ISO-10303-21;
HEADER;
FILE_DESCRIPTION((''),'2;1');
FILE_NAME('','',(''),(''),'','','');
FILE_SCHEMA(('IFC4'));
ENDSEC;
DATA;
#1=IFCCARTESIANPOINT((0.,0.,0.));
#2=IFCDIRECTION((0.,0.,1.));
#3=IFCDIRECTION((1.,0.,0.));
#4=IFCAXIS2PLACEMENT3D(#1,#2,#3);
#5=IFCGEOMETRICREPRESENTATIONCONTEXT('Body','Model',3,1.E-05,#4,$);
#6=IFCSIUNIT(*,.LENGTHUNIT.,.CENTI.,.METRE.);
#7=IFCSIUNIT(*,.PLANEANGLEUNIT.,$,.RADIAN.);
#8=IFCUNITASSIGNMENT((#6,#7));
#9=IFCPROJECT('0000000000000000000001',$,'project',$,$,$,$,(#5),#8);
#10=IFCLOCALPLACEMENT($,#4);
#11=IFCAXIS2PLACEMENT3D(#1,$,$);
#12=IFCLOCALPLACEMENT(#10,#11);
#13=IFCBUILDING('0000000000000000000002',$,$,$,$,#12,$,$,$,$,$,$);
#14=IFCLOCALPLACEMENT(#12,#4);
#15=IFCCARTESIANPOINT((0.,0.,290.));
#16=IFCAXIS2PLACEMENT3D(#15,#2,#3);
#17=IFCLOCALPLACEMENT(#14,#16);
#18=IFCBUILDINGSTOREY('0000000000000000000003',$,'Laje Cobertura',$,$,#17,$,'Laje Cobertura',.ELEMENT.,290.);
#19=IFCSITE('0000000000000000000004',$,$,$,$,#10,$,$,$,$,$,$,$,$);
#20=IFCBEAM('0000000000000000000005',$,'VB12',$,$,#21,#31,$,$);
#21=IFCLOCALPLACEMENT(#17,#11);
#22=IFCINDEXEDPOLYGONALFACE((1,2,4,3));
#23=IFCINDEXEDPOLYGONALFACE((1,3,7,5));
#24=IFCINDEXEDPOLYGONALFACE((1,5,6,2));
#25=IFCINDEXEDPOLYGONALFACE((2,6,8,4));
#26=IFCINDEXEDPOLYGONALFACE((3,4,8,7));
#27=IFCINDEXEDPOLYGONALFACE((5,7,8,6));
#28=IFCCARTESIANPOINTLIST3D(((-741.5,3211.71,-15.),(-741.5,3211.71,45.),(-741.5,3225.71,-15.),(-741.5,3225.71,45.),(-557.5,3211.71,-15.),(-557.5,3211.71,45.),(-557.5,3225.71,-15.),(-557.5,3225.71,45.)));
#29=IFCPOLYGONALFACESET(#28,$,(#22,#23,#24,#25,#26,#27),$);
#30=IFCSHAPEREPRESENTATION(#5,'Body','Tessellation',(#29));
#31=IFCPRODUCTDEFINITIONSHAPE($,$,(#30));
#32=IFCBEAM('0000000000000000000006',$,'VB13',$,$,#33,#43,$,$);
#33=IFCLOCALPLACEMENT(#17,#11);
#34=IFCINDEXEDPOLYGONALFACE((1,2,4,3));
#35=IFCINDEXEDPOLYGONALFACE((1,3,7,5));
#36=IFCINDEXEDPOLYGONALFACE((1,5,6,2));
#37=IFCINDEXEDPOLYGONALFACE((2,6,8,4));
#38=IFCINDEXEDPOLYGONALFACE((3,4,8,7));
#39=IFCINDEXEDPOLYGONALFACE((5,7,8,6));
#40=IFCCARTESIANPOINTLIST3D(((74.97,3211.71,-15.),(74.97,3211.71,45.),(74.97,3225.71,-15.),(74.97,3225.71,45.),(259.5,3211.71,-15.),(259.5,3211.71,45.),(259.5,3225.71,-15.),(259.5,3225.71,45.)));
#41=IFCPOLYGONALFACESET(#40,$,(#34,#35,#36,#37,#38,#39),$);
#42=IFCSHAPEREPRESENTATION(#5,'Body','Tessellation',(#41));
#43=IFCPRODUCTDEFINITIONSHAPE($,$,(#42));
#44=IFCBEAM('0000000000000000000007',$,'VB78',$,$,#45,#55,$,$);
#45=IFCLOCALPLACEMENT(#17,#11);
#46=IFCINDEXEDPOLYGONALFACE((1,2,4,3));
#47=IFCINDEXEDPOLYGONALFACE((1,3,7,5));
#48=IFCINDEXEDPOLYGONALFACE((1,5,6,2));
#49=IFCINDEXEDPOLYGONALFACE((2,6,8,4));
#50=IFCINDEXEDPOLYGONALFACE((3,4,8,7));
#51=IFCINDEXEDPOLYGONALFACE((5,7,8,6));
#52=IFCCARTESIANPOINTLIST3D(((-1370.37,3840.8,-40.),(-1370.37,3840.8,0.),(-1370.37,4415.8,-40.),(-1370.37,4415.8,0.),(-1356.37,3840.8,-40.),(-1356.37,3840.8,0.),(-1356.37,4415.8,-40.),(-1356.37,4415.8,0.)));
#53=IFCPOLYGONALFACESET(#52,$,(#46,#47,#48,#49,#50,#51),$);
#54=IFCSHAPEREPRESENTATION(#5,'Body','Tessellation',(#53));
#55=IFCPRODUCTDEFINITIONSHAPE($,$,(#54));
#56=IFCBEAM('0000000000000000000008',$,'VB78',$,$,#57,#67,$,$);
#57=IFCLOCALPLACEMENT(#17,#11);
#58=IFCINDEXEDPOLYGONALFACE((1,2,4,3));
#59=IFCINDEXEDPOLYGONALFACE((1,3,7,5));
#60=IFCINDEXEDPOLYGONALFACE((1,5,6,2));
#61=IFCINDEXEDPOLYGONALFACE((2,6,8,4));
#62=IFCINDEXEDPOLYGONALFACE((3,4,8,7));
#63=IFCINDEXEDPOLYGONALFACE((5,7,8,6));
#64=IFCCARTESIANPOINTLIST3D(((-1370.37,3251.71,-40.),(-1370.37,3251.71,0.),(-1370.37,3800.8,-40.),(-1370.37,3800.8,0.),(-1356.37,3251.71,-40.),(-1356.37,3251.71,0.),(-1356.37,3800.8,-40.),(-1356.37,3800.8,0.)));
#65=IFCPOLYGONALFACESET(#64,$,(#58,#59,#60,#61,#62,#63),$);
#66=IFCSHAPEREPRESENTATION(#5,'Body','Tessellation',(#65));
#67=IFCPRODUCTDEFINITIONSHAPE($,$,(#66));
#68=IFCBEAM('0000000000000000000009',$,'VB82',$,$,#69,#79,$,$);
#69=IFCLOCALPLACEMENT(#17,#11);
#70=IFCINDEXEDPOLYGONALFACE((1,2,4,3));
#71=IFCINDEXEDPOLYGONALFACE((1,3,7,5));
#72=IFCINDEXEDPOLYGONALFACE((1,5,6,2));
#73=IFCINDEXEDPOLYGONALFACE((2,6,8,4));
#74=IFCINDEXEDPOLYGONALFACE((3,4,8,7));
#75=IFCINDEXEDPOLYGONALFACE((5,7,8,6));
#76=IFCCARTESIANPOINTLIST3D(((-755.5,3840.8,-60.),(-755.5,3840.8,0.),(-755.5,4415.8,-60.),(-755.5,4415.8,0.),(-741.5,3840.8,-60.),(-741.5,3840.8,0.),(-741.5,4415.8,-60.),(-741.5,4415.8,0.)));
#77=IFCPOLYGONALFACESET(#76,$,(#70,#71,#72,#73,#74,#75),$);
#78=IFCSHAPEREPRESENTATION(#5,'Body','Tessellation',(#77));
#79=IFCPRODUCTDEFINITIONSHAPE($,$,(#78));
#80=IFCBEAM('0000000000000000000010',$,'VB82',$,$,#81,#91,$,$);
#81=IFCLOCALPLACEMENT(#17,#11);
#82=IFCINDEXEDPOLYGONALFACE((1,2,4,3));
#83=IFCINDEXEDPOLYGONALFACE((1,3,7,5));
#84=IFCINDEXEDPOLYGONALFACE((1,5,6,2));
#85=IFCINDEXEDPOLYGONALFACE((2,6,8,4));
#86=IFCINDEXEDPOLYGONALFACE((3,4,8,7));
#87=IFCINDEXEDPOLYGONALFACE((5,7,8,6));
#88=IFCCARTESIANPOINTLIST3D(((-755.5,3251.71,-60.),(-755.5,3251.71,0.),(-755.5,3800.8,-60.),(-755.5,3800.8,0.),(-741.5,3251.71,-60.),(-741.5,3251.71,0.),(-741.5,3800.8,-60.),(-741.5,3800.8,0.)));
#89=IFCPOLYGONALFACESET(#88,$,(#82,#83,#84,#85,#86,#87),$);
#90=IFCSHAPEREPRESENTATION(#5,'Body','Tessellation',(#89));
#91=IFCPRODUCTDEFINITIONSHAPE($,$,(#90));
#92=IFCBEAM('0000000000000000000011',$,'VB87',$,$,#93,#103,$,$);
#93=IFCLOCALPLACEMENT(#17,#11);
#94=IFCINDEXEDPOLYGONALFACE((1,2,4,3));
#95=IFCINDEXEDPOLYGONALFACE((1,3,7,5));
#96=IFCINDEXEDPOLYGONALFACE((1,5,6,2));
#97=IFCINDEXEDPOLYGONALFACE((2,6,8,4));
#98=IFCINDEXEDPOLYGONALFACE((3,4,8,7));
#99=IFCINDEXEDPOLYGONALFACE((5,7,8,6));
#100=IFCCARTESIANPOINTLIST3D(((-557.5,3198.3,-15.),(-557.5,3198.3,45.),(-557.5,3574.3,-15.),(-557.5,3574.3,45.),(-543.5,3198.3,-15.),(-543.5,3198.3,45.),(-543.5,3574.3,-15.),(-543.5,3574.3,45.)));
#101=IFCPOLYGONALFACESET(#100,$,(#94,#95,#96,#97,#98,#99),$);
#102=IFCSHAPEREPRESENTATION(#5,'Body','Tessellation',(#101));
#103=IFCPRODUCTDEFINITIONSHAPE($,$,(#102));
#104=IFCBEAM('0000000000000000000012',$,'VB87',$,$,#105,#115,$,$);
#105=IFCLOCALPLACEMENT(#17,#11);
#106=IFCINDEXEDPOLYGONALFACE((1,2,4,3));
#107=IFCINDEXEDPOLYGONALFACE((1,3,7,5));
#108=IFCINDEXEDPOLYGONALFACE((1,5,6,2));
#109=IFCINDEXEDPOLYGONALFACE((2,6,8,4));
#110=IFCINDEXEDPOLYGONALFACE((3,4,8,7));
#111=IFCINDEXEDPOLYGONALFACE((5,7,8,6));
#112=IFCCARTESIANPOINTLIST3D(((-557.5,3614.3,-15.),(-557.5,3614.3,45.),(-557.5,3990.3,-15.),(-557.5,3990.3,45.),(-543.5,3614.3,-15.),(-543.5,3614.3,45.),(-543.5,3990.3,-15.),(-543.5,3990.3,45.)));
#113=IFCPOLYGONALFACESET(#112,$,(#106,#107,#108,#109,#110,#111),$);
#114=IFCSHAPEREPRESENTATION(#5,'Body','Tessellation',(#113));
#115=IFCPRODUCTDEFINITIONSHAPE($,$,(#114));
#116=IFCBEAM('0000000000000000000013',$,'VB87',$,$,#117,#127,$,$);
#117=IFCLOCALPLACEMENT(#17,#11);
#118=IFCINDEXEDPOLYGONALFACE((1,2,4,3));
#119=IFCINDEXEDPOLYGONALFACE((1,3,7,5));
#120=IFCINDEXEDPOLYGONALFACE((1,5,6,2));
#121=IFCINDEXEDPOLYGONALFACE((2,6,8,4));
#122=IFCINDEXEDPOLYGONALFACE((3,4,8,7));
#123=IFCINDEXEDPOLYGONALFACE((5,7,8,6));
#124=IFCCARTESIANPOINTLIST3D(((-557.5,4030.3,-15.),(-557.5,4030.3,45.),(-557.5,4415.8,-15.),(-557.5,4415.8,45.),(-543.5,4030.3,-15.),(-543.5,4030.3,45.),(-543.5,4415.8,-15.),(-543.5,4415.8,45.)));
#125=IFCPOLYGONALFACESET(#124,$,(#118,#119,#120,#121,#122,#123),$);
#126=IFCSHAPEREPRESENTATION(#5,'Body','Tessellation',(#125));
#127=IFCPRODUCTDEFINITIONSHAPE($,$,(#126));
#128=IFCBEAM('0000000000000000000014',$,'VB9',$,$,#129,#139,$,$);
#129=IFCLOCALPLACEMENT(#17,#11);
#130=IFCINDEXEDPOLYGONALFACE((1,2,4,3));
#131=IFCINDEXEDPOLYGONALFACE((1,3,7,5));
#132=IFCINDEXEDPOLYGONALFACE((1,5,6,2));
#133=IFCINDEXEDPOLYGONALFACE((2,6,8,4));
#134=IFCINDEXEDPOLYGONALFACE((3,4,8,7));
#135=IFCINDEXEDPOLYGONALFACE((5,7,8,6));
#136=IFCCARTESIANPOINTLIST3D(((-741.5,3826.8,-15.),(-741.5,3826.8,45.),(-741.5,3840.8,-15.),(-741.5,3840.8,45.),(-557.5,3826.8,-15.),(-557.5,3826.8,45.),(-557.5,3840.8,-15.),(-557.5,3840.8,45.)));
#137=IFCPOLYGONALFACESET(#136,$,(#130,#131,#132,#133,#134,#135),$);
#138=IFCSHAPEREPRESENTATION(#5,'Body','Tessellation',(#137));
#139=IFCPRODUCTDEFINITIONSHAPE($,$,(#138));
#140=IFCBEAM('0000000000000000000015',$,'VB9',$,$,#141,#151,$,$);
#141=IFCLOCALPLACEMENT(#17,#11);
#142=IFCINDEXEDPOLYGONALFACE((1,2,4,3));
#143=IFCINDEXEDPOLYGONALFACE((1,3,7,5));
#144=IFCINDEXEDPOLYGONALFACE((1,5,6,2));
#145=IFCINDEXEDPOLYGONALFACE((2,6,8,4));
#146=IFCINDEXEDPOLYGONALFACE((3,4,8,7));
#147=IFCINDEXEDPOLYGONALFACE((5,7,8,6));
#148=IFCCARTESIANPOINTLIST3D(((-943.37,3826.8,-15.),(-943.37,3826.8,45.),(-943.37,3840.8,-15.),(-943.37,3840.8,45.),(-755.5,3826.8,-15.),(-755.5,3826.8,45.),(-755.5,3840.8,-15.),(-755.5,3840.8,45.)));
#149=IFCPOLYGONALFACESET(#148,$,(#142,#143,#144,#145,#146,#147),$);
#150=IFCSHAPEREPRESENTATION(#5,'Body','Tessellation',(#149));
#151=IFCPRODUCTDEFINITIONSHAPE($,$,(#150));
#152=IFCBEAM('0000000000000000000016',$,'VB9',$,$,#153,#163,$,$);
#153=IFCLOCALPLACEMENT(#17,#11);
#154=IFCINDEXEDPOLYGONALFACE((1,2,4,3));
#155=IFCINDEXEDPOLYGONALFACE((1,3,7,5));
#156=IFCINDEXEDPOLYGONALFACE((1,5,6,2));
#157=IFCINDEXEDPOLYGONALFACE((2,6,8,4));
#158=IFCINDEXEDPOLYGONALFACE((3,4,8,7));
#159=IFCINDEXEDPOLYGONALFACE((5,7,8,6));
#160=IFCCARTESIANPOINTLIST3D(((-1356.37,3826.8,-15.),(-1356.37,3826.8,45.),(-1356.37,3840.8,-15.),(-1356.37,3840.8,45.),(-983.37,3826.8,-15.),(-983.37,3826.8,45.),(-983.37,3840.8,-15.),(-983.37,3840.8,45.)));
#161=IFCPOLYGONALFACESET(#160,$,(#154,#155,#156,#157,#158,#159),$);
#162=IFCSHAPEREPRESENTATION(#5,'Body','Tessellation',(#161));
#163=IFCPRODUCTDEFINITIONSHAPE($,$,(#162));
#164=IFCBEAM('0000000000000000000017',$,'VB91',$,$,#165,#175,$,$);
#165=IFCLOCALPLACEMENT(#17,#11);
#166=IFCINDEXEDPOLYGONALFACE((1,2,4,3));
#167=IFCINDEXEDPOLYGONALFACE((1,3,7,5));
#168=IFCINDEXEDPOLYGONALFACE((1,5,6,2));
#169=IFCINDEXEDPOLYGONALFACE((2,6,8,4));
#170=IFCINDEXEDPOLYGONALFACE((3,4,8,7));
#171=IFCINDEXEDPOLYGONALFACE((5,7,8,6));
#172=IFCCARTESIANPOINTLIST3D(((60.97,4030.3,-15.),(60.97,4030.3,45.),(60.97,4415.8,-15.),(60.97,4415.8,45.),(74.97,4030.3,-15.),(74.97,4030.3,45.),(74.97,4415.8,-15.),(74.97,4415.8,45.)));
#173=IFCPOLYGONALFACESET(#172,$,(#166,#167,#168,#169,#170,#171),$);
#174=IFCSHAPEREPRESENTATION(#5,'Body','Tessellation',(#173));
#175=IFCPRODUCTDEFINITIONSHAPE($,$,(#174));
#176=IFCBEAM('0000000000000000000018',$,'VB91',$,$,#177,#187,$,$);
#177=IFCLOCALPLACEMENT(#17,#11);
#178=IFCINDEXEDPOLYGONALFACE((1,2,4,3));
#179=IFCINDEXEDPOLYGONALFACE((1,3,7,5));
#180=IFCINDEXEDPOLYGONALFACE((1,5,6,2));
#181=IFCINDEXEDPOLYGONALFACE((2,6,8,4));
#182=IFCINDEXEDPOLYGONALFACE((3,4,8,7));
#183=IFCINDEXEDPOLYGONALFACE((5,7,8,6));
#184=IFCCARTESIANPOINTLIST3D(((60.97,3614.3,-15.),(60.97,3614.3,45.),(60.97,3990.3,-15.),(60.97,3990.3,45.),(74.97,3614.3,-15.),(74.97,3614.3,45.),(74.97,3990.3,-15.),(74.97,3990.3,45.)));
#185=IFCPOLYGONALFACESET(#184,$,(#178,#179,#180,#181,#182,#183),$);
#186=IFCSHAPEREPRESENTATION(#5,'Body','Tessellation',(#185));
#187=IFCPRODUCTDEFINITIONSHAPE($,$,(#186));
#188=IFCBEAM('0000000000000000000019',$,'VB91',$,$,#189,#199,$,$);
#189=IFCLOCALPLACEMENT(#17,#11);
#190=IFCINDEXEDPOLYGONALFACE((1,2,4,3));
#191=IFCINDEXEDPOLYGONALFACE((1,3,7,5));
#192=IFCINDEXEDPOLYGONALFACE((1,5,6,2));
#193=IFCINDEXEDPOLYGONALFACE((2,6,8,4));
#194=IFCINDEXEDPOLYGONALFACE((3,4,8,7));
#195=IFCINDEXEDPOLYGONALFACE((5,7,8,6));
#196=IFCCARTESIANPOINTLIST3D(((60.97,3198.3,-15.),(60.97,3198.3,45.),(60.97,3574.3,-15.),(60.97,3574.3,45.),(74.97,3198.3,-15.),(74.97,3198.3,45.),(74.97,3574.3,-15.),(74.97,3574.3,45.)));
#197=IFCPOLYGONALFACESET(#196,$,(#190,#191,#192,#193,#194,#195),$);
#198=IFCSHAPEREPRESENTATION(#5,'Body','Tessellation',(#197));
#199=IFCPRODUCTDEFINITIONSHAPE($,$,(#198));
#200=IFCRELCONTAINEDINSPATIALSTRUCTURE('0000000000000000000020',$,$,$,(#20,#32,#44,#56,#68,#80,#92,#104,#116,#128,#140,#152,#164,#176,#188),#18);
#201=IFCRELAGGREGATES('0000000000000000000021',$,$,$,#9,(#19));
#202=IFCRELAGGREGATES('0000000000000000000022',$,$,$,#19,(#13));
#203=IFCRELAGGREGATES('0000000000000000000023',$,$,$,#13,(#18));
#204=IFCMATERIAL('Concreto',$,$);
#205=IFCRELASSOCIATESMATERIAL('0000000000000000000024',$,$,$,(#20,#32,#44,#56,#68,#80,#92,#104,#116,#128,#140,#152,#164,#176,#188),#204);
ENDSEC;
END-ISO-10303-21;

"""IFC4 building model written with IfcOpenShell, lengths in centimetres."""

from ifc_helpers import new_model, si_unit, frame, origin, origin_with_axes, origin_2d_with_axis, place, context, project, spatial, rectangle, extrude, material, element, save


model = new_model("IFC4")

# Units and contexts
model_context = context("Model", 3, precision=1e-05, world=origin_with_axes(), identifier="Body")
ifc_project = project(units=[si_unit("LENGTHUNIT", "METRE", prefix="CENTI"), si_unit("PLANEANGLEUNIT", "RADIAN")], contexts=[model_context])

# Site, building, storey
site_placement = place(None, origin_with_axes())
site = spatial("IfcSite", under=ifc_project, at=site_placement)
building_placement = place(site_placement, origin())
building = spatial("IfcBuilding", under=site, at=building_placement)
placement = place(building_placement, origin_with_axes())
storey_placement = place(placement, frame((0.0, 0.0, 290.0), z_axis=(0.0, 0.0, 1.0), x_axis=(1.0, 0.0, 0.0)))
storey = spatial("IfcBuildingStorey", under=building, at=storey_placement, Name="Laje Cobertura", LongName="Laje Cobertura", CompositionType="ELEMENT", Elevation=290.0)

# Shared definitions
ifc_material = material(Name="Concreto")

# Beams
beam_1_placement = place(storey_placement, frame((-649.5, 3218.71, 45.0), z_axis=(0.0, 0.0, 1.0), x_axis=(1.0, 0.0, 0.0)))
element("IfcBeam", 1, at=beam_1_placement, inside=storey, material=ifc_material, Name="VB12", context=model_context, shape_type="SolidModel", body=[
    extrude(rectangle(XDim=14.0, YDim=60.0, at=origin_2d_with_axis()), frame((-92.0, 0.0, -30.0), z_axis=(1.0, 0.0, 0.0), x_axis=(0.0, 1.0, 0.0)), (0.0, 0.0, 1.0), 184.0),
])
beam_2_placement = place(storey_placement, frame((167.24, 3218.71, 45.0), z_axis=(0.0, 0.0, 1.0), x_axis=(1.0, 0.0, 0.0)))
element("IfcBeam", 2, at=beam_2_placement, inside=storey, material=ifc_material, Name="VB13", context=model_context, shape_type="SolidModel", body=[
    extrude(rectangle(XDim=14.0, YDim=60.0, at=origin_2d_with_axis()), frame((-92.27, 0.0, -30.0), z_axis=(1.0, 0.0, 0.0), x_axis=(0.0, 1.0, 0.0)), (0.0, 0.0, 1.0), 184.53),
])
beam_3_placement = place(storey_placement, frame((-1363.37, 4128.3, 0.0), z_axis=(0.0, 0.0, 1.0), x_axis=(1.0, 0.0, 0.0)))
element("IfcBeam", 3, at=beam_3_placement, inside=storey, material=ifc_material, Name="VB78", context=model_context, shape_type="SolidModel", body=[
    extrude(rectangle(XDim=14.0, YDim=40.0, at=origin_2d_with_axis()), frame((0.0, -287.5, -20.0), z_axis=(0.0, 1.0, 0.0), x_axis=(-1.0, 0.0, 0.0)), (0.0, 0.0, 1.0), 575.0),
])
beam_4_placement = place(storey_placement, frame((-1363.37, 3526.26, 0.0), z_axis=(0.0, 0.0, 1.0), x_axis=(1.0, 0.0, 0.0)))
element("IfcBeam", 4, at=beam_4_placement, inside=storey, material=ifc_material, Name="VB78", context=model_context, shape_type="SolidModel", body=[
    extrude(rectangle(XDim=14.0, YDim=40.0, at=origin_2d_with_axis()), frame((0.0, -274.55, -20.0), z_axis=(0.0, 1.0, 0.0), x_axis=(-1.0, 0.0, 0.0)), (0.0, 0.0, 1.0), 549.09),
])
beam_5_placement = place(storey_placement, frame((-748.5, 4128.3, 0.0), z_axis=(0.0, 0.0, 1.0), x_axis=(1.0, 0.0, 0.0)))
element("IfcBeam", 5, at=beam_5_placement, inside=storey, material=ifc_material, Name="VB82", context=model_context, shape_type="SolidModel", body=[
    extrude(rectangle(XDim=14.0, YDim=60.0, at=origin_2d_with_axis()), frame((0.0, -287.5, -30.0), z_axis=(0.0, 1.0, 0.0), x_axis=(-1.0, 0.0, 0.0)), (0.0, 0.0, 1.0), 575.0),
])
beam_6_placement = place(storey_placement, frame((-748.5, 3526.26, 0.0), z_axis=(0.0, 0.0, 1.0), x_axis=(1.0, 0.0, 0.0)))
element("IfcBeam", 6, at=beam_6_placement, inside=storey, material=ifc_material, Name="VB82", context=model_context, shape_type="SolidModel", body=[
    extrude(rectangle(XDim=14.0, YDim=60.0, at=origin_2d_with_axis()), frame((0.0, -274.55, -30.0), z_axis=(0.0, 1.0, 0.0), x_axis=(-1.0, 0.0, 0.0)), (0.0, 0.0, 1.0), 549.09),
])
for number, where, z_axis, x_axis, name in (
    (7, (-550.5, 3386.3, 45.0), (0.0, 0.0, 1.0), (1.0, 0.0, 0.0), "VB87"),
    (8, (-550.5, 3802.3, 45.0), (0.0, 0.0, 1.0), (1.0, 0.0, 0.0), "VB87"),
):
    element("IfcBeam", number, at=place(storey_placement, frame(where, z_axis=z_axis, x_axis=x_axis)), inside=storey, material=ifc_material, Name=name, context=model_context, shape_type="SolidModel", body=[
        extrude(rectangle(XDim=14.0, YDim=60.0, at=origin_2d_with_axis()), frame((0.0, -188.0, -30.0), z_axis=(0.0, 1.0, 0.0), x_axis=(-1.0, 0.0, 0.0)), (0.0, 0.0, 1.0), 376.0),
    ])
beam_7_placement = place(storey_placement, frame((-550.5, 4223.05, 45.0), z_axis=(0.0, 0.0, 1.0), x_axis=(1.0, 0.0, 0.0)))
element("IfcBeam", 9, at=beam_7_placement, inside=storey, material=ifc_material, Name="VB87", context=model_context, shape_type="SolidModel", body=[
    extrude(rectangle(XDim=14.0, YDim=60.0, at=origin_2d_with_axis()), frame((0.0, -192.75, -30.0), z_axis=(0.0, 1.0, 0.0), x_axis=(-1.0, 0.0, 0.0)), (0.0, 0.0, 1.0), 385.5),
])
beam_8_placement = place(storey_placement, frame((-649.5, 3833.8, 45.0), z_axis=(0.0, 0.0, 1.0), x_axis=(1.0, 0.0, 0.0)))
element("IfcBeam", 10, at=beam_8_placement, inside=storey, material=ifc_material, Name="VB9", context=model_context, shape_type="SolidModel", body=[
    extrude(rectangle(XDim=14.0, YDim=60.0, at=origin_2d_with_axis()), frame((-92.0, 0.0, -30.0), z_axis=(1.0, 0.0, 0.0), x_axis=(0.0, 1.0, 0.0)), (0.0, 0.0, 1.0), 184.0),
])
beam_9_placement = place(storey_placement, frame((-849.43, 3833.8, 45.0), z_axis=(0.0, 0.0, 1.0), x_axis=(1.0, 0.0, 0.0)))
element("IfcBeam", 11, at=beam_9_placement, inside=storey, material=ifc_material, Name="VB9", context=model_context, shape_type="SolidModel", body=[
    extrude(rectangle(XDim=14.0, YDim=60.0, at=origin_2d_with_axis()), frame((-93.94, 0.0, -30.0), z_axis=(1.0, 0.0, 0.0), x_axis=(0.0, 1.0, 0.0)), (0.0, 0.0, 1.0), 187.87),
])
beam_10_placement = place(storey_placement, frame((-1169.87, 3833.8, 45.0), z_axis=(0.0, 0.0, 1.0), x_axis=(1.0, 0.0, 0.0)))
element("IfcBeam", 12, at=beam_10_placement, inside=storey, material=ifc_material, Name="VB9", context=model_context, shape_type="SolidModel", body=[
    extrude(rectangle(XDim=14.0, YDim=60.0, at=origin_2d_with_axis()), frame((-186.5, 0.0, -30.0), z_axis=(1.0, 0.0, 0.0), x_axis=(0.0, 1.0, 0.0)), (0.0, 0.0, 1.0), 373.0),
])
beam_11_placement = place(storey_placement, frame((67.97, 4223.05, 45.0), z_axis=(0.0, 0.0, 1.0), x_axis=(1.0, 0.0, 0.0)))
element("IfcBeam", 13, at=beam_11_placement, inside=storey, material=ifc_material, Name="VB91", context=model_context, shape_type="SolidModel", body=[
    extrude(rectangle(XDim=14.0, YDim=60.0, at=origin_2d_with_axis()), frame((0.0, -192.75, -30.0), z_axis=(0.0, 1.0, 0.0), x_axis=(-1.0, 0.0, 0.0)), (0.0, 0.0, 1.0), 385.5),
])
for number, where, z_axis, x_axis, name in (
    (14, (67.97, 3802.3, 45.0), (0.0, 0.0, 1.0), (1.0, 0.0, 0.0), "VB91"),
    (15, (67.97, 3386.3, 45.0), (0.0, 0.0, 1.0), (1.0, 0.0, 0.0), "VB91"),
):
    element("IfcBeam", number, at=place(storey_placement, frame(where, z_axis=z_axis, x_axis=x_axis)), inside=storey, material=ifc_material, Name=name, context=model_context, shape_type="SolidModel", body=[
        extrude(rectangle(XDim=14.0, YDim=60.0, at=origin_2d_with_axis()), frame((0.0, -188.0, -30.0), z_axis=(0.0, 1.0, 0.0), x_axis=(-1.0, 0.0, 0.0)), (0.0, 0.0, 1.0), 376.0),
    ])

save(model, "model.ifc")
